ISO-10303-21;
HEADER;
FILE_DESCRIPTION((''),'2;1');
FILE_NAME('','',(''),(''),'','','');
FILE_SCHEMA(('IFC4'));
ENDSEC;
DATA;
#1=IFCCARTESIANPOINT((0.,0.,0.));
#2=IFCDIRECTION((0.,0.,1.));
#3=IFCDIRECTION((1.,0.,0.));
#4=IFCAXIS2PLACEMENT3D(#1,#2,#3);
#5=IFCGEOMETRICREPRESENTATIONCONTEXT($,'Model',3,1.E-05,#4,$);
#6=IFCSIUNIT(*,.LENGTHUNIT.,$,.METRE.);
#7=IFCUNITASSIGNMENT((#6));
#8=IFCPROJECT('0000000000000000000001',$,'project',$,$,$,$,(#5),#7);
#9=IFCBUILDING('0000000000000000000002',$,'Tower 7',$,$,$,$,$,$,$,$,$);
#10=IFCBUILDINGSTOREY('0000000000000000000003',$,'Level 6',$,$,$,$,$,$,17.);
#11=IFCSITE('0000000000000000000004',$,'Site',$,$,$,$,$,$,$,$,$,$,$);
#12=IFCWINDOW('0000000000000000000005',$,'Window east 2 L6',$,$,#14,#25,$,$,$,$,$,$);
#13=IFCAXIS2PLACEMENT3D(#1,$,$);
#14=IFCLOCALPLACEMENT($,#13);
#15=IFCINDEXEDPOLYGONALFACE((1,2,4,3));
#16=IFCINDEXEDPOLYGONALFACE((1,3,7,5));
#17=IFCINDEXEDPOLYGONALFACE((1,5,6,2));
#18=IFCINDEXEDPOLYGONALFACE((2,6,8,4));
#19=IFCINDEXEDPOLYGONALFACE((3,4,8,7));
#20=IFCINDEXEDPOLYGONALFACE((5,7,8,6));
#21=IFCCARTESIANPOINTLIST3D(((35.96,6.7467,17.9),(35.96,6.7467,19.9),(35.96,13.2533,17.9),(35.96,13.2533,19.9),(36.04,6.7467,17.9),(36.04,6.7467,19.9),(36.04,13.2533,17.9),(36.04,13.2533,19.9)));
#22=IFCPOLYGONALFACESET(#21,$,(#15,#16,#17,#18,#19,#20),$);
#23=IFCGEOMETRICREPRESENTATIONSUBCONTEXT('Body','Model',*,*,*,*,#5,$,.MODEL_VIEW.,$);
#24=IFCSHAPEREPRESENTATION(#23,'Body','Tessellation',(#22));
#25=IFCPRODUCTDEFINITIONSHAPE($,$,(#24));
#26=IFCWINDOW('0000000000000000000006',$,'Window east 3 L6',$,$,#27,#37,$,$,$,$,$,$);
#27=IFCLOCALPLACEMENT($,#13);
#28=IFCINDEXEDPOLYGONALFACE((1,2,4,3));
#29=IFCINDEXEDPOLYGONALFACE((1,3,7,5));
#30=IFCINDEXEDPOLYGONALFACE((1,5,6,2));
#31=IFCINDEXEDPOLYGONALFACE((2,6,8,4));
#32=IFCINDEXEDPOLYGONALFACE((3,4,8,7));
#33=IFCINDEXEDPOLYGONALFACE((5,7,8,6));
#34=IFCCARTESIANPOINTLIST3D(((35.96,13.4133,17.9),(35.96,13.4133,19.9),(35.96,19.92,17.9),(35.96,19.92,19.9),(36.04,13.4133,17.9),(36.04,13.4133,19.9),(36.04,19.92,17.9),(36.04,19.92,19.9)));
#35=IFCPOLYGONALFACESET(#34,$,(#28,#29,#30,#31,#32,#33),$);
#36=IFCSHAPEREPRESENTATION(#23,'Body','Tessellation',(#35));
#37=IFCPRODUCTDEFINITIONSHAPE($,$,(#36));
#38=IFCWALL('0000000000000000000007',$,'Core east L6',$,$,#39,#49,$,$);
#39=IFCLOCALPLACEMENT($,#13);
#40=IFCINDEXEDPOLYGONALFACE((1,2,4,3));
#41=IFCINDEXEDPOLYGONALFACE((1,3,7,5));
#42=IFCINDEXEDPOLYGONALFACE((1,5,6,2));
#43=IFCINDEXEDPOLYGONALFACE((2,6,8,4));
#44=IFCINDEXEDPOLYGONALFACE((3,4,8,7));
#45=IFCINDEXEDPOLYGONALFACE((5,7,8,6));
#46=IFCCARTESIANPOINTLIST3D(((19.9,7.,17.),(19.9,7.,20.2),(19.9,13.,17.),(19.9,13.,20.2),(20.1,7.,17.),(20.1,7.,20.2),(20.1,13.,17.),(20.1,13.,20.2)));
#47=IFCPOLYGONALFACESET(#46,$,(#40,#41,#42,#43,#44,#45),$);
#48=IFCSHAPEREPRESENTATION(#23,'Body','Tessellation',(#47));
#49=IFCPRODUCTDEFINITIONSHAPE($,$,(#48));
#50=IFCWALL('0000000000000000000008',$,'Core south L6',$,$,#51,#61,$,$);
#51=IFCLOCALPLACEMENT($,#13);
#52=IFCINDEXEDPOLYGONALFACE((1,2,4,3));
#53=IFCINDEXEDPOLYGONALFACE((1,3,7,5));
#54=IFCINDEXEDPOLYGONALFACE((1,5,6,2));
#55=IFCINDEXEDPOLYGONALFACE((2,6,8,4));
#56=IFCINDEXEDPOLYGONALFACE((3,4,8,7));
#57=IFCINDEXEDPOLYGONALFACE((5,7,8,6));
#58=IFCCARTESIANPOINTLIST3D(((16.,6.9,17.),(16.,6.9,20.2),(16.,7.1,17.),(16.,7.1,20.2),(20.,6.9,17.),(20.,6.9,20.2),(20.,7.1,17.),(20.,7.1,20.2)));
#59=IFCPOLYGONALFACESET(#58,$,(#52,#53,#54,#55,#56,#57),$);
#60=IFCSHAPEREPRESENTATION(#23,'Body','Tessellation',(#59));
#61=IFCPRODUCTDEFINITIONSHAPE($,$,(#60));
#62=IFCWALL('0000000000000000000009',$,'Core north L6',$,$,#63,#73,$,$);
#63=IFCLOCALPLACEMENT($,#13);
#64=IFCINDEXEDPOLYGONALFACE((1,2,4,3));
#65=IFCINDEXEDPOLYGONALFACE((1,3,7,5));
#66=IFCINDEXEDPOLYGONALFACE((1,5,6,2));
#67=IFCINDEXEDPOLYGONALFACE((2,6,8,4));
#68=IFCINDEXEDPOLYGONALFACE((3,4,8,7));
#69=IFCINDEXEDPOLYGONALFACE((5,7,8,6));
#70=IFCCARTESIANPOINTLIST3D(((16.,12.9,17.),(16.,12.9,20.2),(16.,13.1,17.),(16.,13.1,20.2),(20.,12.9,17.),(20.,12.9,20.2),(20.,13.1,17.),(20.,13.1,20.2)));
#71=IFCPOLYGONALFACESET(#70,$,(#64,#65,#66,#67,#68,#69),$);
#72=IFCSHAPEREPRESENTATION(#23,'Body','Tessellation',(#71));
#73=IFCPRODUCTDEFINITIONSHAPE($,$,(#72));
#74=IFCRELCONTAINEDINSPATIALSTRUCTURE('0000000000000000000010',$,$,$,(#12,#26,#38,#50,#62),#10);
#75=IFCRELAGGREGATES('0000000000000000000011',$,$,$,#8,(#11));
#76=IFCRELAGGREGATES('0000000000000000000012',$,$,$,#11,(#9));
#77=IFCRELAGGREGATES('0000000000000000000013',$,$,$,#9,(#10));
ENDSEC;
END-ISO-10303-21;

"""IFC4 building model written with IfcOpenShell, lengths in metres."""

from ifc_helpers import new_model, si_unit, frame, origin, origin_with_axes, origin_2d, place, context, subcontext, project, spatial, rectangle, extrude, element, save


model = new_model("IFC4")

# Units and contexts
model_context = context("Model", 3, precision=1e-05, world=origin_with_axes())
body_context = subcontext(model_context, "Body", "Model", "MODEL_VIEW")
ifc_project = project(units=[si_unit("LENGTHUNIT", "METRE")], contexts=[model_context])

# Site, building, storey
site = spatial("IfcSite", under=ifc_project, Name="Site")
building = spatial("IfcBuilding", under=site, Name="Tower 7")
storey = spatial("IfcBuildingStorey", under=building, Name="Level 6", Elevation=17.0)

# Windows
for number, where, z_axis, x_axis, name in (
    (1, (36.0, 10.0, 17.9), (0.0, 0.0, 1.0), (1.0, 0.0, 0.0), "Window east 2 L6"),
):
    element("IfcWindow", number, at=place(None, frame(where, z_axis=z_axis, x_axis=x_axis)), inside=storey, Name=name, context=body_context, shape_type="SweptSolid", body=[
        extrude(rectangle(XDim=0.08, YDim=6.5067, at=origin_2d()), origin(), (0.0, 0.0, 1.0), 2.0),
    ])
window_placement = place(None, frame((36.0, 16.6667, 17.9), z_axis=(0.0, 0.0, 1.0), x_axis=(1.0, 0.0, 0.0)))
element("IfcWindow", 2, at=window_placement, inside=storey, Name="Window east 3 L6", context=body_context, shape_type="SweptSolid", body=[
    extrude(rectangle(XDim=0.08, YDim=6.5067, at=origin_2d()), origin(), (0.0, 0.0, 1.0), 2.0),
])

# Walls
wall_1_placement = place(None, frame((20.0, 10.0, 17.0), z_axis=(0.0, 0.0, 1.0), x_axis=(1.0, 0.0, 0.0)))
element("IfcWall", 3, at=wall_1_placement, inside=storey, Name="Core east L6", context=body_context, shape_type="SweptSolid", body=[
    extrude(rectangle(XDim=0.2, YDim=6.0, at=origin_2d()), origin(), (0.0, 0.0, 1.0), 3.2),
])
for number, where, z_axis, x_axis, name in (
    (4, (18.0, 7.0, 17.0), (0.0, 0.0, 1.0), (1.0, 0.0, 0.0), "Core south L6"),
    (5, (18.0, 13.0, 17.0), (0.0, 0.0, 1.0), (1.0, 0.0, 0.0), "Core north L6"),
):
    element("IfcWall", number, at=place(None, frame(where, z_axis=z_axis, x_axis=x_axis)), inside=storey, Name=name, context=body_context, shape_type="SweptSolid", body=[
        extrude(rectangle(XDim=4.0, YDim=0.2, at=origin_2d()), origin(), (0.0, 0.0, 1.0), 3.2),
    ])

save(model, "model.ifc")
